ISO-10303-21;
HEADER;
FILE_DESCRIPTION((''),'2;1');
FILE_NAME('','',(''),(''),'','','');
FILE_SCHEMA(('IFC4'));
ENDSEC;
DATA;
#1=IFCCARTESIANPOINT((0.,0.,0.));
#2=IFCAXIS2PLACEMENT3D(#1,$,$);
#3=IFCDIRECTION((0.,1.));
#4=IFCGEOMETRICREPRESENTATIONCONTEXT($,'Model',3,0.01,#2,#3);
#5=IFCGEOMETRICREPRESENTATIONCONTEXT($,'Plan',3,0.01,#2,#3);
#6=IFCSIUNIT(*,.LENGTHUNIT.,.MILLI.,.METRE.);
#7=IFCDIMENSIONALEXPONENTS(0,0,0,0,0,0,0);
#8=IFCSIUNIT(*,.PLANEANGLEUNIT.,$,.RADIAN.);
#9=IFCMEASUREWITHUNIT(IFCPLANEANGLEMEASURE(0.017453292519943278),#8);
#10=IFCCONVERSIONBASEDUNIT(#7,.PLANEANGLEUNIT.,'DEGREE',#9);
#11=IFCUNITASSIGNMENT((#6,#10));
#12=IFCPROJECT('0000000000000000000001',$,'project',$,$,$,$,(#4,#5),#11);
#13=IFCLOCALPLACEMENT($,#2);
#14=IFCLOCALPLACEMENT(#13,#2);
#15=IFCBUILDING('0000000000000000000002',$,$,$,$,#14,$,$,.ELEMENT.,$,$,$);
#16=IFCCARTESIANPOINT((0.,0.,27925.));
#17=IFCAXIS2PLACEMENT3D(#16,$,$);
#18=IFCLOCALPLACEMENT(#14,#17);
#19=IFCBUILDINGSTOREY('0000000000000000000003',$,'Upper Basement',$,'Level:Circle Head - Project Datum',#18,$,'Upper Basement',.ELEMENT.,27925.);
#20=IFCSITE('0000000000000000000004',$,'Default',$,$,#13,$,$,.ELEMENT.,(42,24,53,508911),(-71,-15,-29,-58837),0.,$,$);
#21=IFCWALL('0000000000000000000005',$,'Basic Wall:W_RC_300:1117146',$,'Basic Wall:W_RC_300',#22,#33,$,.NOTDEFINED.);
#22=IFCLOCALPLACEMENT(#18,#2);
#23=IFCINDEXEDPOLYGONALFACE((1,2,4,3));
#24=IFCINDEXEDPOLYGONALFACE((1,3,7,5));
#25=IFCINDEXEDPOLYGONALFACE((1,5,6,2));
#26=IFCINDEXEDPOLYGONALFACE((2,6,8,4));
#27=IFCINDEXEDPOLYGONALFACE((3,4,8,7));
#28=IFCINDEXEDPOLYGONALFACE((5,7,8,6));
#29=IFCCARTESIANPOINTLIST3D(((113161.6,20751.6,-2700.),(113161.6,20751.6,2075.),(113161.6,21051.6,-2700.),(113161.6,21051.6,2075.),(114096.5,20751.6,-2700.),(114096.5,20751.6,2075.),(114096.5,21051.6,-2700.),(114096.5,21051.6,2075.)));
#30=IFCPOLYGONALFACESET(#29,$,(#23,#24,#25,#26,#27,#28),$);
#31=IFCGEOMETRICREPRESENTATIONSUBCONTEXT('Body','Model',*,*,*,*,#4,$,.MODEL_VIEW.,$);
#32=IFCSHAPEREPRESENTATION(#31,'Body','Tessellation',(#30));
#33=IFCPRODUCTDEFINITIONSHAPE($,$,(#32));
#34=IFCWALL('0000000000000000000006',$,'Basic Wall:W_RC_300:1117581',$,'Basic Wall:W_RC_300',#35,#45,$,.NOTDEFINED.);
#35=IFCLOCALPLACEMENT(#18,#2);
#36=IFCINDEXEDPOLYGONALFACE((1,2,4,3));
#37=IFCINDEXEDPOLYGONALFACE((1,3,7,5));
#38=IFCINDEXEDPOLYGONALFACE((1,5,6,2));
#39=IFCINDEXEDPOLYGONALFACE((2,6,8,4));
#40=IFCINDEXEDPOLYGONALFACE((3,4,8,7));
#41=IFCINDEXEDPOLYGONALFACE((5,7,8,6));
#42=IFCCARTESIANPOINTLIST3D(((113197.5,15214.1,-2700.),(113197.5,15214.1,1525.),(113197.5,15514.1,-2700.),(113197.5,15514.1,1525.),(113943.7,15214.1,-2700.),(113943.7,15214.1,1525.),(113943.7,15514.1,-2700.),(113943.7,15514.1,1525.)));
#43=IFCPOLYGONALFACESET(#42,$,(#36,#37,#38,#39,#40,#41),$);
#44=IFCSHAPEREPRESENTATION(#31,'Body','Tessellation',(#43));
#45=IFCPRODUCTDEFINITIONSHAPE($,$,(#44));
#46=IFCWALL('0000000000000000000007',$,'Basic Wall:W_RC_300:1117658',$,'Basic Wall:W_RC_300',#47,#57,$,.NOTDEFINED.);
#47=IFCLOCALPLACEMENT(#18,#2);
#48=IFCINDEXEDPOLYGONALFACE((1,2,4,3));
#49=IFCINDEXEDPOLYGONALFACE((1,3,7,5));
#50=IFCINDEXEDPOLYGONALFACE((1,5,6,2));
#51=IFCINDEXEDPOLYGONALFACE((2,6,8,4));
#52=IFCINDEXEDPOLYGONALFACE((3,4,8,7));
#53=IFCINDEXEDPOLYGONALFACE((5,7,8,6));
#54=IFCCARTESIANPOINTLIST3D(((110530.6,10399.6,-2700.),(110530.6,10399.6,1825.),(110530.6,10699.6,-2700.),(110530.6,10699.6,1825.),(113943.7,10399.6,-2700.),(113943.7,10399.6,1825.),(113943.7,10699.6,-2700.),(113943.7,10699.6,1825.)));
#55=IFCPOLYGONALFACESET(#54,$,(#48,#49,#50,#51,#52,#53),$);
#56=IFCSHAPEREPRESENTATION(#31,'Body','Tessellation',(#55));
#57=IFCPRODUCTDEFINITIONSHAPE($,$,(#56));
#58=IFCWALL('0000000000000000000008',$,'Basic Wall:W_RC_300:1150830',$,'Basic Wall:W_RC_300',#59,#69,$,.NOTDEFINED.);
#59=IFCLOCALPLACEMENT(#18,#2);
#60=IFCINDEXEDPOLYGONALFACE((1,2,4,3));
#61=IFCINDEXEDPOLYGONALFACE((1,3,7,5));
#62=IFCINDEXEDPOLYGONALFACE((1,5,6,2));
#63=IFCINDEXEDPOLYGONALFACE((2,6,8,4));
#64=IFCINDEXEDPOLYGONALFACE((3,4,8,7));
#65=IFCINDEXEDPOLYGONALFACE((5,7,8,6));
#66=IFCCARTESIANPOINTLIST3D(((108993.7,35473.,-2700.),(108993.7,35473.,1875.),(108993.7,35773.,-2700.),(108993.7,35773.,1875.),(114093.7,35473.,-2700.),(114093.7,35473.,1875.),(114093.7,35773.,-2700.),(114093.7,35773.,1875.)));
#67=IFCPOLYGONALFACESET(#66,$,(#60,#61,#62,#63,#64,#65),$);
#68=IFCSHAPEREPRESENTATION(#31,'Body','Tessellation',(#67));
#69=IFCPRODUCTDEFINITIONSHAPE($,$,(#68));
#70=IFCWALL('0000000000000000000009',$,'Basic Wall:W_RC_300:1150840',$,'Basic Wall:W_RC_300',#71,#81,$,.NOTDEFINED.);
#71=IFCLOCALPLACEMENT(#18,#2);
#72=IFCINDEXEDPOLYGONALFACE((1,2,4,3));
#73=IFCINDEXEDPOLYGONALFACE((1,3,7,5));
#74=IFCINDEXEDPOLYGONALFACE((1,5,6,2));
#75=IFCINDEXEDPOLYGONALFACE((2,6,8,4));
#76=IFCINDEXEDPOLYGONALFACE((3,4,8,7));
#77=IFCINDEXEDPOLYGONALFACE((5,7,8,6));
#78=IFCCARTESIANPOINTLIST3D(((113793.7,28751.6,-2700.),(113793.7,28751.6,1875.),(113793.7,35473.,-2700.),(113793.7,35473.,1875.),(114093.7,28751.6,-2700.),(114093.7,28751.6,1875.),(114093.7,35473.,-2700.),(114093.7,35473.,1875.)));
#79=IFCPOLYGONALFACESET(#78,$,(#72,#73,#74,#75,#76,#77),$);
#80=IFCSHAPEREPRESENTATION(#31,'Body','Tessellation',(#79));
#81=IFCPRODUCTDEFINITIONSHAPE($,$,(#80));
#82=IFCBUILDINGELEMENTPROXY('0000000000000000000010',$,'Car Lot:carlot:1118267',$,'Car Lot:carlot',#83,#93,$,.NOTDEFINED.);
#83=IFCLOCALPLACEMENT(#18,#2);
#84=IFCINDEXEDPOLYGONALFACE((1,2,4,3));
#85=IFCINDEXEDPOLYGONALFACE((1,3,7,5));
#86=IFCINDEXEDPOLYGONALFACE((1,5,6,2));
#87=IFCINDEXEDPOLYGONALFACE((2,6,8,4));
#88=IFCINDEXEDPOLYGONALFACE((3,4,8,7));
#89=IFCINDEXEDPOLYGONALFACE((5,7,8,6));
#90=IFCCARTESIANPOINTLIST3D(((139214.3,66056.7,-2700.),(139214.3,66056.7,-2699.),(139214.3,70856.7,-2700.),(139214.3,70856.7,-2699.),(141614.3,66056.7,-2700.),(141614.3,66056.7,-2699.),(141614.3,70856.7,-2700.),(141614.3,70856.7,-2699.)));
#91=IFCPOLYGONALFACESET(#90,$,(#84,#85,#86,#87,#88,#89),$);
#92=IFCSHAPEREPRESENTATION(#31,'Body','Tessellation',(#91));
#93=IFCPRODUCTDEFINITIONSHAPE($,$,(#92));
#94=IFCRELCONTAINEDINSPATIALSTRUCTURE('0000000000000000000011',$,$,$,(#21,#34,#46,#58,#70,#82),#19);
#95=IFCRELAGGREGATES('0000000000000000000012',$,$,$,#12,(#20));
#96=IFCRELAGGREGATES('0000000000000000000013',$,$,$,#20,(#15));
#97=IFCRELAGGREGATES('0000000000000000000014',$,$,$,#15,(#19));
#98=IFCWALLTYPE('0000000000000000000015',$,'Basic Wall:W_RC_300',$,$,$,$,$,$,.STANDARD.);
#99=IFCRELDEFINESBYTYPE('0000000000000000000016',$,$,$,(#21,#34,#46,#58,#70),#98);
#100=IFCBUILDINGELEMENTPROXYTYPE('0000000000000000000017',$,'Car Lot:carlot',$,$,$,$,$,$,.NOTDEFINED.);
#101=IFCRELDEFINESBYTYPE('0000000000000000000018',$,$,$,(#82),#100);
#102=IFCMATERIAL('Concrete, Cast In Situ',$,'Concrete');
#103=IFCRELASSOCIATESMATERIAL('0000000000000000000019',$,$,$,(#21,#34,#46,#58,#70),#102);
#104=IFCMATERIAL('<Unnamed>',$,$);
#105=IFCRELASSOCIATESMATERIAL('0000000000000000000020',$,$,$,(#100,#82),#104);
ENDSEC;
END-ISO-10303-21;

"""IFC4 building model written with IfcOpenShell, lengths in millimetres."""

from ifc_helpers import new_model, entity, si_unit, converted_unit, direction, frame, origin, place, context, subcontext, project, spatial, indexed_curve, outline, extrude, source, transform, mapped, material, type_object, type_shapes, element, save


model = new_model("IFC4")

# Units and contexts
model_context = context("Model", 3, precision=0.01, world=origin(), true_north=direction((0.0, 1.0)))
plan_context = context("Plan", 3, precision=0.01, world=origin(), true_north=direction((0.0, 1.0)))
body_context = subcontext(model_context, "Body", "Model", "MODEL_VIEW")
ifc_project = project(units=[si_unit("LENGTHUNIT", "METRE", prefix="MILLI"), converted_unit("PLANEANGLEUNIT", "DEGREE", entity("IfcPlaneAngleMeasure", 0.017453292519943278), si_unit("PLANEANGLEUNIT", "RADIAN"), dimensions=[0, 0, 0, 0, 0, 0, 0])], contexts=[model_context, plan_context])

# Site, building, storey
site_placement = place(None, origin())
site = spatial("IfcSite", under=ifc_project, at=site_placement, Name="Default", CompositionType="ELEMENT", RefLatitude=(42, 24, 53, 508911), RefLongitude=(-71, -15, -29, -58837), RefElevation=0.0)
building_placement = place(site_placement, origin())
building = spatial("IfcBuilding", under=site, at=building_placement, CompositionType="ELEMENT")
storey_placement = place(building_placement, frame((0.0, 0.0, 27925.0)))
storey = spatial("IfcBuildingStorey", under=building, at=storey_placement, Name="Upper Basement", ObjectType="Level:Circle Head - Project Datum", LongName="Upper Basement", CompositionType="ELEMENT", Elevation=27925.0)

# Walls
ifc_material_1 = material(Name="Concrete, Cast In Situ", Category="Concrete")
wall_type = type_object("IfcWallType", Name="Basic Wall:W_RC_300", PredefinedType="STANDARD")
wall_1_placement = place(storey_placement, frame((113161.6, 20901.6, -2700.0)))
element("IfcWall", 1, at=wall_1_placement, inside=storey, type_object=wall_type, material=ifc_material_1, Name="Basic Wall:W_RC_300:1117146", ObjectType="Basic Wall:W_RC_300", PredefinedType="NOTDEFINED", context=body_context, shape_type="SweptSolid", body=[
    extrude(outline(indexed_curve([(934.9, 150.0), (0.0, 150.0), (0.0, -150.0), (934.9, -150.0), (934.9, 150.0)], self_intersect=False)), origin(), (0.0, 0.0, 1.0), 4775.0),
])
wall_2_placement = place(storey_placement, frame((113197.5, 15364.1, -2700.0)))
element("IfcWall", 2, at=wall_2_placement, inside=storey, type_object=wall_type, material=ifc_material_1, Name="Basic Wall:W_RC_300:1117581", ObjectType="Basic Wall:W_RC_300", PredefinedType="NOTDEFINED", context=body_context, shape_type="SweptSolid", body=[
    extrude(outline(indexed_curve([(746.2, 150.0), (0.0, 150.0), (0.0, -150.0), (746.2, -150.0), (746.2, 150.0)], self_intersect=False)), origin(), (0.0, 0.0, 1.0), 4225.0),
])
wall_3_placement = place(storey_placement, frame((110530.6, 10549.6, -2700.0)))
element("IfcWall", 3, at=wall_3_placement, inside=storey, type_object=wall_type, material=ifc_material_1, Name="Basic Wall:W_RC_300:1117658", ObjectType="Basic Wall:W_RC_300", PredefinedType="NOTDEFINED", context=body_context, shape_type="SweptSolid", body=[
    extrude(outline(indexed_curve([(3413.1, 150.0), (0.0, 150.0), (0.0, -150.0), (3413.1, -150.0), (3413.1, 150.0)], self_intersect=False)), origin(), (0.0, 0.0, 1.0), 4525.0),
])
wall_4_placement = place(storey_placement, frame((114093.7, 35623.0, -2700.0), z_axis=(0.0, 0.0, 1.0), x_axis=(-1.0, 0.0, 0.0)))
element("IfcWall", 4, at=wall_4_placement, inside=storey, type_object=wall_type, material=ifc_material_1, Name="Basic Wall:W_RC_300:1150830", ObjectType="Basic Wall:W_RC_300", PredefinedType="NOTDEFINED", context=body_context, shape_type="SweptSolid", body=[
    extrude(outline(indexed_curve([(5100.0, 150.0), (0.0, 150.0), (0.0, -150.0), (5100.0, -150.0), (5100.0, 150.0)], self_intersect=False)), origin(), (0.0, 0.0, 1.0), 4575.0),
])
wall_5_placement = place(storey_placement, frame((113943.7, 35473.0, -2700.0), z_axis=(0.0, 0.0, 1.0), x_axis=(0.0, -1.0, 0.0)))
element("IfcWall", 5, at=wall_5_placement, inside=storey, type_object=wall_type, material=ifc_material_1, Name="Basic Wall:W_RC_300:1150840", ObjectType="Basic Wall:W_RC_300", PredefinedType="NOTDEFINED", context=body_context, shape_type="SweptSolid", body=[
    extrude(outline(indexed_curve([(6721.4, 150.0), (0.0, 150.0), (0.0, -150.0), (6721.4, -150.0), (6721.4, 150.0)], self_intersect=False)), origin(), (0.0, 0.0, 1.0), 4575.0),
])

# Building element proxy
ifc_material_2 = material(Name="<Unnamed>")
building_element_proxy_type = type_object("IfcBuildingElementProxyType", Name="Car Lot:carlot", PredefinedType="NOTDEFINED", material=ifc_material_2)
shared_shape = source(origin(), body_context, "Body", "SweptSolid", [
    extrude(outline(indexed_curve([(-1200.0, -2400.0), (1200.0, -2400.0), (1200.0, 2400.0), (-1200.0, 2400.0), (-1200.0, -2400.0)], self_intersect=False)), frame((0.0, 0.0, 0.0), z_axis=(0.0, 0.0, 1.0), x_axis=(-1.0, 0.0, 0.0)), (0.0, 0.0, 1.0), 1.0),
])
type_shapes(building_element_proxy_type, [shared_shape])
proxy_placement = place(storey_placement, frame((140414.3, 68456.7, -2700.0)))
element("IfcBuildingElementProxy", 6, at=proxy_placement, inside=storey, type_object=building_element_proxy_type, material=ifc_material_2, Name="Car Lot:carlot:1118267", ObjectType="Car Lot:carlot", PredefinedType="NOTDEFINED", context=body_context, shape_type="MappedRepresentation", body=[
    mapped(shared_shape, transform((0.0, 0.0, 0.0), scale=1.0)),
])

save(model, "model.ifc")
